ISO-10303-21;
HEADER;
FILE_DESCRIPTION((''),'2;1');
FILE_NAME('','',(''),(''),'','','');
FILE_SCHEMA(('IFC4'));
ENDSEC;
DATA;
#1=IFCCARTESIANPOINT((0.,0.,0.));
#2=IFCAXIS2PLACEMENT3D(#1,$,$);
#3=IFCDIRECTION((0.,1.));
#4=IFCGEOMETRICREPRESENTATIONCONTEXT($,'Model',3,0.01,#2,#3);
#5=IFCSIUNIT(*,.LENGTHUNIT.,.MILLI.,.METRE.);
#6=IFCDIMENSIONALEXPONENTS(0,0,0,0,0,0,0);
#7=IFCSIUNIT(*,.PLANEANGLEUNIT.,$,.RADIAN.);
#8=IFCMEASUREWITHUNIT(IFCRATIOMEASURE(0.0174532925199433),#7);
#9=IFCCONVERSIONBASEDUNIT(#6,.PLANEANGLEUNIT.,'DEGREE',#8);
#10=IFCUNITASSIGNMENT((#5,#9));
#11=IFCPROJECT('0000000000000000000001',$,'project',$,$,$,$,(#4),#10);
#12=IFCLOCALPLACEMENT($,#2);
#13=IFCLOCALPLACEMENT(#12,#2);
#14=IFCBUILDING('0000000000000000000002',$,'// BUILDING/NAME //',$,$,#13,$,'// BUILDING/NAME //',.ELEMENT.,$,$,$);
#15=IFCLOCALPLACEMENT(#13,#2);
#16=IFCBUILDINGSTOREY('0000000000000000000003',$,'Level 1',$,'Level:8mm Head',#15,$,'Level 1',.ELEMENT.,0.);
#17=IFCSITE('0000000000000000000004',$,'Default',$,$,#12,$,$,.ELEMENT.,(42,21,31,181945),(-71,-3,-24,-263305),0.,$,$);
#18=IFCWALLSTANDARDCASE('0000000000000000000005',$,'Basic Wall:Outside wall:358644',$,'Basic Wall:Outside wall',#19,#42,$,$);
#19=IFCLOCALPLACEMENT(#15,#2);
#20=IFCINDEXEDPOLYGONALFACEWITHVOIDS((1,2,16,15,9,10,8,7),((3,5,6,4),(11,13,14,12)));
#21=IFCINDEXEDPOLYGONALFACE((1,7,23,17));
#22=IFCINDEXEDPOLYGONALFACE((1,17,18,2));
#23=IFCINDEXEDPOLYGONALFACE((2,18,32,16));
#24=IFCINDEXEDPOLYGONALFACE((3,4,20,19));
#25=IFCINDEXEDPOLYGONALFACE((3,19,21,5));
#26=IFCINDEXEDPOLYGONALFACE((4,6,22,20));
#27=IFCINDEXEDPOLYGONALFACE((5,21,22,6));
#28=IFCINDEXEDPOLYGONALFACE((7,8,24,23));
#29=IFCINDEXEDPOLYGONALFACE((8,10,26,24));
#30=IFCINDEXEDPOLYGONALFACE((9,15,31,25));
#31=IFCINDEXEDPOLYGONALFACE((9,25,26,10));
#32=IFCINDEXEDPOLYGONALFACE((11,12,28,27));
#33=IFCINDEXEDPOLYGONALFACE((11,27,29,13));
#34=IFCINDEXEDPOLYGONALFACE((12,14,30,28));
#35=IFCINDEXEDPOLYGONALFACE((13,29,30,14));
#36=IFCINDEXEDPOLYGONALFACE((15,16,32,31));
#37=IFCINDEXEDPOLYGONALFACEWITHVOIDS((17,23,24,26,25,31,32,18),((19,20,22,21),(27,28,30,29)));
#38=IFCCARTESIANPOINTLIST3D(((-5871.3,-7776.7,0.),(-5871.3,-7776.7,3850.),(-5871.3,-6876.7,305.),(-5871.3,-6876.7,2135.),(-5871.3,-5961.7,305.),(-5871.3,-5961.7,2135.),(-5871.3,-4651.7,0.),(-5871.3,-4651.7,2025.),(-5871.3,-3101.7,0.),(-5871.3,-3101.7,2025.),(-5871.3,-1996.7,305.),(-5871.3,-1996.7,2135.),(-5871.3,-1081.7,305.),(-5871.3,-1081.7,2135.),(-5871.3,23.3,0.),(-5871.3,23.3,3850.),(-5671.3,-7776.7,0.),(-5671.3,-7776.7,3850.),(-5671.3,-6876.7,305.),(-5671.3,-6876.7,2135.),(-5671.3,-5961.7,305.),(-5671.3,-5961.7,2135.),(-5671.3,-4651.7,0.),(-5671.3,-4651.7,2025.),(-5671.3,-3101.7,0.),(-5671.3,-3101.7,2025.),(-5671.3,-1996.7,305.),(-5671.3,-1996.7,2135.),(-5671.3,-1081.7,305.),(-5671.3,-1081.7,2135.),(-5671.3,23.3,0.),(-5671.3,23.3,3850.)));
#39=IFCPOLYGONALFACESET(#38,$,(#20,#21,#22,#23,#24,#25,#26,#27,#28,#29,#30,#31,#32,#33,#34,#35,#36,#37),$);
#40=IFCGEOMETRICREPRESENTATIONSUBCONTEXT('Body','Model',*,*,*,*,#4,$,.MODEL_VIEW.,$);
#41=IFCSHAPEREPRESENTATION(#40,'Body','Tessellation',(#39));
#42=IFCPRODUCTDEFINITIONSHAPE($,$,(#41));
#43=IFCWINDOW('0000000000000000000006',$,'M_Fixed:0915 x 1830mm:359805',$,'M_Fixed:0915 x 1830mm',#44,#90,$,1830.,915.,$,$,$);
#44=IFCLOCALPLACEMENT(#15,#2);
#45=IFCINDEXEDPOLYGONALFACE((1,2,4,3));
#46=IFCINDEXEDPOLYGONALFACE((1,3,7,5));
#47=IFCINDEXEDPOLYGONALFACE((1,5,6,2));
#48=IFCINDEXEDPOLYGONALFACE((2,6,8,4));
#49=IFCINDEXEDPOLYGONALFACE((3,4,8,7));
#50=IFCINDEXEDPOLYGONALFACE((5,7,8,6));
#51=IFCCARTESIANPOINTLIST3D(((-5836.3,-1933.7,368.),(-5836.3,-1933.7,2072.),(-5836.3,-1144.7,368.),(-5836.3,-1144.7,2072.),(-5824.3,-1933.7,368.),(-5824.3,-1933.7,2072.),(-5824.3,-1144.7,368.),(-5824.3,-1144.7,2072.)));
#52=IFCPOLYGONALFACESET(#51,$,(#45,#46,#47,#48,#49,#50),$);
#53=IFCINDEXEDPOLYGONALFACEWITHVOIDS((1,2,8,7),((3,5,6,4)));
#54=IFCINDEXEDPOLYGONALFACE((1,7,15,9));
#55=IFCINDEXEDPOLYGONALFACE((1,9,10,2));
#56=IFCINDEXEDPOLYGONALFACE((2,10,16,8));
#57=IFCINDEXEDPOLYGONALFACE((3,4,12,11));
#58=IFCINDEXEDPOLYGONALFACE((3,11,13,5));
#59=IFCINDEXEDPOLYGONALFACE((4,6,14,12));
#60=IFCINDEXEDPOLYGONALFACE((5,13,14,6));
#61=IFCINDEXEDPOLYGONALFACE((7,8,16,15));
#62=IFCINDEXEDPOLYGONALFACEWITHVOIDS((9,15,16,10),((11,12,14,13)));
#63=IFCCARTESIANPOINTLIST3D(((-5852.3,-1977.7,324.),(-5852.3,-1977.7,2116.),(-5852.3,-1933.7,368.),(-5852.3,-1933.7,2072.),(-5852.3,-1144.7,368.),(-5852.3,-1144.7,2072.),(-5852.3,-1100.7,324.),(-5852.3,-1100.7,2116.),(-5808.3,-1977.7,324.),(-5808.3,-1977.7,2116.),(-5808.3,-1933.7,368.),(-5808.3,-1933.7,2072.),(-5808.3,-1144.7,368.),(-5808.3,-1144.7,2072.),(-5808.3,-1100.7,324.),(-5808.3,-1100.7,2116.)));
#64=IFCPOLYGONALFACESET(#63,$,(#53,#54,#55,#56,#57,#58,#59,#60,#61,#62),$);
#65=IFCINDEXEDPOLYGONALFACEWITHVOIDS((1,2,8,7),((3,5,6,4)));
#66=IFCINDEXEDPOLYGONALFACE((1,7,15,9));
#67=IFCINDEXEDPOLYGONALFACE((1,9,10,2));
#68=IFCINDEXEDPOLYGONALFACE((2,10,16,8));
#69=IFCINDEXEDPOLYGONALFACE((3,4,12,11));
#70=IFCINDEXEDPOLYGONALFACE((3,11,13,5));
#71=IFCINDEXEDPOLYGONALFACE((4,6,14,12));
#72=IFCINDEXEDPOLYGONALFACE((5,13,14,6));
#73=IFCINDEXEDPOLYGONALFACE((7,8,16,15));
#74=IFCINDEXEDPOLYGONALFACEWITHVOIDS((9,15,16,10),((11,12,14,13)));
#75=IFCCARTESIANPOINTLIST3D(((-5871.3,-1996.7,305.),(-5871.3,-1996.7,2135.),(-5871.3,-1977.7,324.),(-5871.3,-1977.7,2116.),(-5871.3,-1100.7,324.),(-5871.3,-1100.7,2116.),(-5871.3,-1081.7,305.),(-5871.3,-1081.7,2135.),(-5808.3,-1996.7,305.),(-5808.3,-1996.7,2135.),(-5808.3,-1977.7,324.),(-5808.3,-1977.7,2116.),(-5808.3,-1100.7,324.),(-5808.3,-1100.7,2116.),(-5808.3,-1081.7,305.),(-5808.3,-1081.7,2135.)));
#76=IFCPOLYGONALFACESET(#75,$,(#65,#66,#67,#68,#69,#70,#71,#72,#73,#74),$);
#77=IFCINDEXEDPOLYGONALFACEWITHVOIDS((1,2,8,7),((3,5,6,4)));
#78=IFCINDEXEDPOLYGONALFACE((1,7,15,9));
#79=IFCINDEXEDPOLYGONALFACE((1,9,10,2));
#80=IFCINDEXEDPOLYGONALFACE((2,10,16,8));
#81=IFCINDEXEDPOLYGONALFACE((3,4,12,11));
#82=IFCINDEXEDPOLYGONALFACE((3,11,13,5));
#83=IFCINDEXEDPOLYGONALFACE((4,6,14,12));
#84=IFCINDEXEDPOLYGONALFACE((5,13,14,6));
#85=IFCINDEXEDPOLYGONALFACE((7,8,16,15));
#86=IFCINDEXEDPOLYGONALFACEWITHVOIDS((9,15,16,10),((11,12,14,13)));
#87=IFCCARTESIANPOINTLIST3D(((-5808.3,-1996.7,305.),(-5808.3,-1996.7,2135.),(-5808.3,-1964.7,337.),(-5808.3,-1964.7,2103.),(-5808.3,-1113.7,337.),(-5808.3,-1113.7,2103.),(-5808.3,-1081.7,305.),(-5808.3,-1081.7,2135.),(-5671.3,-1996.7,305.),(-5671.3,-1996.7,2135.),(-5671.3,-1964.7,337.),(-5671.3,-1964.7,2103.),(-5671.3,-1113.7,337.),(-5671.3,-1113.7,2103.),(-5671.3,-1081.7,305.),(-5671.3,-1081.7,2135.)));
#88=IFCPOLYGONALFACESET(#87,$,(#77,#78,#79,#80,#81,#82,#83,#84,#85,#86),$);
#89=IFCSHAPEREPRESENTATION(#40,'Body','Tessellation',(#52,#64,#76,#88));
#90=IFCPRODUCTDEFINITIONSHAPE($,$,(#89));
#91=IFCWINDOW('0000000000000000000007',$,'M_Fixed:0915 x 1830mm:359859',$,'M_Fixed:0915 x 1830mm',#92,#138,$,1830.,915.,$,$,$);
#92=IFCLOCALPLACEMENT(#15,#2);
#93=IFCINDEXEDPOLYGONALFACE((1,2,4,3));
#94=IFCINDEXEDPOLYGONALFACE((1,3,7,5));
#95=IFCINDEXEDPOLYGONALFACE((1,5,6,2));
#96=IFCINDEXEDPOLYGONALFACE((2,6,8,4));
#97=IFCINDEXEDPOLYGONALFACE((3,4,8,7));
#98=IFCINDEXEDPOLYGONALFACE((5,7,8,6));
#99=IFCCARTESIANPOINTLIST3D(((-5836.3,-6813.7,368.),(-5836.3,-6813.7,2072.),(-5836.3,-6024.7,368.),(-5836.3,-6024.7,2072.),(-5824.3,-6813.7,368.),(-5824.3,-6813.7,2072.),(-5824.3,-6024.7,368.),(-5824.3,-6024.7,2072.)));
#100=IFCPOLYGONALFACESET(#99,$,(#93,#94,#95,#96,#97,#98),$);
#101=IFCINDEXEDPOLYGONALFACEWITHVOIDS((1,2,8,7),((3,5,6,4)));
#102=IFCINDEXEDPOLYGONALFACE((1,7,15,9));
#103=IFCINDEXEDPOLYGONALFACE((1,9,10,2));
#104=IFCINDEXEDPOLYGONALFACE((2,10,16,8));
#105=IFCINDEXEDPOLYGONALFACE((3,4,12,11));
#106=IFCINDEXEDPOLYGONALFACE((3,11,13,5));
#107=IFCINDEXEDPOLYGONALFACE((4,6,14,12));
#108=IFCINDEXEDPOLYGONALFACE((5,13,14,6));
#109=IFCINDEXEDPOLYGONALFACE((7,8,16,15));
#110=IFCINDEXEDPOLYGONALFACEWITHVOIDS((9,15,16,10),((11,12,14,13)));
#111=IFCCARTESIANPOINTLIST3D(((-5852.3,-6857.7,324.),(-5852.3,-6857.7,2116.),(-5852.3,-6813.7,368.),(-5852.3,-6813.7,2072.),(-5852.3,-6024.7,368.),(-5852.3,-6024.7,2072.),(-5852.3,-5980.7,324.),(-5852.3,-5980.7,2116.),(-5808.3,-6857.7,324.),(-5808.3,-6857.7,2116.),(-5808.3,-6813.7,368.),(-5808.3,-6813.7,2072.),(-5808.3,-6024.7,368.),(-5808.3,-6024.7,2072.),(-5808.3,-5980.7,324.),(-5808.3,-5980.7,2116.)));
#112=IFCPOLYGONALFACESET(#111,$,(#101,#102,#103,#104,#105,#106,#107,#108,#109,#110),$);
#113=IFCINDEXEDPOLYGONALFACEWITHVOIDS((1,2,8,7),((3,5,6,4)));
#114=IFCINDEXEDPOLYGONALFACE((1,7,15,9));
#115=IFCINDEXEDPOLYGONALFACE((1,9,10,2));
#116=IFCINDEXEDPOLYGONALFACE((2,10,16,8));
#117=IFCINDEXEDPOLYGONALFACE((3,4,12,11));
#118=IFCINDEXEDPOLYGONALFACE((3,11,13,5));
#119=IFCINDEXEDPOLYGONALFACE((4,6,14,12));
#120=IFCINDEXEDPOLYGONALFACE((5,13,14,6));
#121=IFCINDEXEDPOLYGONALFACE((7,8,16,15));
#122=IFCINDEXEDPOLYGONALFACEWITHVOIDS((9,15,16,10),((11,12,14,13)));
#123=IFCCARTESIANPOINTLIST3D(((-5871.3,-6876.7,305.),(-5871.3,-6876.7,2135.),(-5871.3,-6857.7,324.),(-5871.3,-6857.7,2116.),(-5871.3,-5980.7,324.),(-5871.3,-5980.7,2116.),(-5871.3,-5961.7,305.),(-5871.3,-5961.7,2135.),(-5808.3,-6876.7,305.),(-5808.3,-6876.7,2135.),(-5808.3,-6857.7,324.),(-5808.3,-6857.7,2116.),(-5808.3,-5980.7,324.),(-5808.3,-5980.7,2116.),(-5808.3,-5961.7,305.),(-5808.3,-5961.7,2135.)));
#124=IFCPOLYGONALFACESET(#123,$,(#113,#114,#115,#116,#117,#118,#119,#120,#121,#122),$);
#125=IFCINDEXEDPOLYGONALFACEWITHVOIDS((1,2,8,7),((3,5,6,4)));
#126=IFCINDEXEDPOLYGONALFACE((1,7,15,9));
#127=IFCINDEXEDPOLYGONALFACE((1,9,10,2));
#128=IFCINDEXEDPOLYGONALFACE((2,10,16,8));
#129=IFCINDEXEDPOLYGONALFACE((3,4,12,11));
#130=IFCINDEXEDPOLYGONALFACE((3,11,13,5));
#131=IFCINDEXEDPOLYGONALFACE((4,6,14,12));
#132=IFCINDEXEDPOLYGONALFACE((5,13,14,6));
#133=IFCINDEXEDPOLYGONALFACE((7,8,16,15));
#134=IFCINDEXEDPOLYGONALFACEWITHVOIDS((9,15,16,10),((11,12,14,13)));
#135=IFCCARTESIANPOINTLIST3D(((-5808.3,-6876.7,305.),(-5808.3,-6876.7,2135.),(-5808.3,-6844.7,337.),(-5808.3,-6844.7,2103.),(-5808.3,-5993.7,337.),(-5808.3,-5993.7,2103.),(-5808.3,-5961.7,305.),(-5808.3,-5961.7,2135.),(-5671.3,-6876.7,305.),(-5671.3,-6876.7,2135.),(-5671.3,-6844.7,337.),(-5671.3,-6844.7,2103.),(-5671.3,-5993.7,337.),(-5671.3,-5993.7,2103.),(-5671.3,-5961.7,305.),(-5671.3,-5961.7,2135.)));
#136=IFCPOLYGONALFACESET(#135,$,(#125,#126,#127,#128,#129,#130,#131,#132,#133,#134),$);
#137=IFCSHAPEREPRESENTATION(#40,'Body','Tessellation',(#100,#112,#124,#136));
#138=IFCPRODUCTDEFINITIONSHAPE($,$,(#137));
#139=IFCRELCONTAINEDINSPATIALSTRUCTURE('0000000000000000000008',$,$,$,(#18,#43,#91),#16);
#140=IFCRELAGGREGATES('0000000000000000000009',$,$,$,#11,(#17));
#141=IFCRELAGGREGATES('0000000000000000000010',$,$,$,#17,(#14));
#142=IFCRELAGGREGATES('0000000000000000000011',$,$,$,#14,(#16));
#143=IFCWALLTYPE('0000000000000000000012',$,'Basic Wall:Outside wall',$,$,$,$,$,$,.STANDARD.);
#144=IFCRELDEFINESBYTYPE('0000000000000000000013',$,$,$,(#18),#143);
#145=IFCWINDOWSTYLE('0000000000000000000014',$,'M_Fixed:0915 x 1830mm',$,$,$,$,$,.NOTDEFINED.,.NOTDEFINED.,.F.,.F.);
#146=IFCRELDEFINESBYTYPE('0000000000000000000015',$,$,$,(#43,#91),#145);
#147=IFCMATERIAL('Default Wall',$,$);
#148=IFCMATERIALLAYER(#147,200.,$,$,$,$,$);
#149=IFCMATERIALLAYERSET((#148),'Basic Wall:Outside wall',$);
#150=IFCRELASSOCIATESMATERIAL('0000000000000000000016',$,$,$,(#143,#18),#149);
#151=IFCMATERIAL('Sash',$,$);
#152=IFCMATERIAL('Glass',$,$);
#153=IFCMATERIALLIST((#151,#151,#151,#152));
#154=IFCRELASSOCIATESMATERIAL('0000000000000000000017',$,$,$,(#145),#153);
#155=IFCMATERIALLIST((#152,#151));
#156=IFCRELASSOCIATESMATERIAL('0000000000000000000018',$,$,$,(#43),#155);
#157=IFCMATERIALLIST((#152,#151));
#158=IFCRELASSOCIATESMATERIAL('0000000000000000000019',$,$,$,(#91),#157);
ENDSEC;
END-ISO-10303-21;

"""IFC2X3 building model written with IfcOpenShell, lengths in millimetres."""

from ifc_helpers import new_model, entity, si_unit, converted_unit, direction, frame, frame_2d, origin, place, context, subcontext, project, spatial, polyline, rectangle, outline, extrude, clip, halfspace, bounded_halfspace, source, transform, mapped, material, material_list, layer, layer_set, layer_usage, type_object, type_shapes, element, fill, save


model = new_model("IFC2X3")

# Units and contexts
model_context = context("Model", 3, precision=0.01, world=origin(), true_north=direction((0.0, 1.0)))
body_context = subcontext(model_context, "Body", "Model", "MODEL_VIEW")
ifc_project = project(units=[si_unit("LENGTHUNIT", "METRE", prefix="MILLI"), converted_unit("PLANEANGLEUNIT", "DEGREE", entity("IfcRatioMeasure", 0.0174532925199433), si_unit("PLANEANGLEUNIT", "RADIAN"), dimensions=[0, 0, 0, 0, 0, 0, 0])], contexts=[model_context])

# Site, building, storey
site_placement = place(None, origin())
site = spatial("IfcSite", under=ifc_project, at=site_placement, Name="Default", CompositionType="ELEMENT", RefLatitude=(42, 21, 31, 181945), RefLongitude=(-71, -3, -24, -263305), RefElevation=0.0)
building_placement = place(site_placement, origin())
building = spatial("IfcBuilding", under=site, at=building_placement, Name="// BUILDING/NAME //", LongName="// BUILDING/NAME //", CompositionType="ELEMENT")
storey_placement = place(building_placement, origin())
storey = spatial("IfcBuildingStorey", under=building, at=storey_placement, Name="Level 1", ObjectType="Level:8mm Head", LongName="Level 1", CompositionType="ELEMENT", Elevation=0.0)

# Shared definitions
ifc_material_1 = material(Name="Default Wall")
ifc_layer_1 = layer(ifc_material_1, 200.0)
ifc_layer_set_1 = layer_set([ifc_layer_1], Name="Basic Wall:Outside wall")
wall_type_1 = type_object("IfcWallType", Name="Basic Wall:Outside wall", PredefinedType="STANDARD", material=ifc_layer_set_1)
ifc_material_2 = material(Name="Glass")
ifc_material_3 = material(Name="Sash")
ifc_material_list_1 = material_list([ifc_material_3, ifc_material_3, ifc_material_3, ifc_material_2])
window_style = type_object("IfcWindowStyle", Name="M_Fixed:0915 x 1830mm", ConstructionType="NOTDEFINED", OperationType="NOTDEFINED", ParameterTakesPrecedence=False, Sizeable=False, material=ifc_material_list_1)
shared_shape_1 = source(origin(), body_context, "Body", "SweptSolid", [
    extrude(rectangle(XDim=12.0, YDim=789.0, at=frame_2d((0.0, 0.0), x_axis=(1.0, 0.0))), frame((457.5, 159.0, 63.0), z_axis=(0.0, 0.0, 1.0), x_axis=(0.0, -1.0, 0.0)), (0.0, 0.0, 1.0), 1704.0),
    extrude(outline(polyline([(-438.5, -896.0), (438.5, -896.0), (438.5, 896.0), (-438.5, 896.0), (-438.5, -896.0)]), holes=[polyline([(-394.5, -852.0), (-394.5, 852.0), (394.5, 852.0), (394.5, -852.0), (-394.5, -852.0)])]), frame((457.5, 137.0, 915.0), z_axis=(0.0, 1.0, 0.0), x_axis=(1.0, 0.0, 0.0)), (0.0, 0.0, 1.0), 44.0),
    extrude(outline(polyline([(-457.5, -915.0), (457.5, -915.0), (457.5, 915.0), (-457.5, 915.0), (-457.5, -915.0)]), holes=[polyline([(-438.5, -896.0), (-438.5, 896.0), (438.5, 896.0), (438.5, -896.0), (-438.5, -896.0)])]), frame((457.5, 137.0, 915.0), z_axis=(0.0, 1.0, 0.0), x_axis=(1.0, 0.0, 0.0)), (0.0, 0.0, 1.0), 63.0),
    extrude(outline(polyline([(-457.5, -915.0), (457.5, -915.0), (457.5, 915.0), (-457.5, 915.0), (-457.5, -915.0)]), holes=[polyline([(-425.5, -883.0), (-425.5, 883.0), (425.5, 883.0), (425.5, -883.0), (-425.5, -883.0)])]), frame((457.5, 0.0, 915.0), z_axis=(0.0, 1.0, 0.0), x_axis=(1.0, 0.0, 0.0)), (0.0, 0.0, 1.0), 137.0),
])
type_shapes(window_style, [shared_shape_1])

# Wall, openings, windows
ifc_layer_usage_1 = layer_usage(ifc_layer_set_1, "AXIS2", "NEGATIVE", 100.0)
wall_1_placement = place(storey_placement, frame((-5771.3, -7776.7, 0.0), z_axis=(0.0, 0.0, 1.0), x_axis=(0.0, 1.0, 0.0)))
wall_1 = element("IfcWallStandardCase", 1, at=wall_1_placement, inside=storey, type_object=wall_type_1, material=ifc_layer_usage_1, Name="Basic Wall:Outside wall:358644", ObjectType="Basic Wall:Outside wall", context=body_context, shape_type="Clipping", body=[
    clip(clip(extrude(rectangle(XDim=7800.0, YDim=200.0, at=frame_2d((3900.0, 0.0), x_axis=(-1.0, 0.0))), origin(), (0.0, 0.0, 1.0), 3850.0), bounded_halfspace(frame((0.0, -100.0, 3850.0), z_axis=(0.0, 0.0, -1.0), x_axis=(-1.0, 0.0, 0.0)), True, frame((0.0, -100.0, 3850.0), z_axis=(0.0, 0.0, -1.0), x_axis=(-1.0, 0.0, 0.0)), polyline([(0.0, 0.0), (0.0, 200.0), (-7800.0, 200.0), (-7800.0, 0.0), (0.0, 0.0)]))), halfspace(origin(), True)),
])
opening_1_placement = place(wall_1_placement, frame((3125.0, -100.0, 0.0)))
element("IfcOpeningElement", 2, at=opening_1_placement, cuts=wall_1, ObjectType="Opening", context=body_context, shape_type="SweptSolid", body=[
    extrude(rectangle(XDim=2025.0, YDim=1550.0, at=frame_2d((1012.5, 775.0), x_axis=(1.0, 0.0))), frame((0.0, 0.0, 0.0), z_axis=(0.0, 1.0, 0.0), x_axis=(0.0, 0.0, 1.0)), (0.0, 0.0, 1.0), 200.0),
])
opening_2_placement = place(wall_1_placement, frame((5780.0, -100.0, 305.0)))
opening_2 = element("IfcOpeningElement", 3, at=opening_2_placement, cuts=wall_1, ObjectType="Opening", context=body_context, shape_type="SweptSolid", body=[
    extrude(rectangle(XDim=1830.0, YDim=915.0, at=frame_2d((915.0, 457.5), x_axis=(1.0, 0.0))), frame((0.0, 0.0, 0.0), z_axis=(0.0, 1.0, 0.0), x_axis=(0.0, 0.0, 1.0)), (0.0, 0.0, 1.0), 200.0),
])
opening_3_placement = place(wall_1_placement, frame((900.0, -100.0, 305.0)))
opening_3 = element("IfcOpeningElement", 4, at=opening_3_placement, cuts=wall_1, ObjectType="Opening", context=body_context, shape_type="SweptSolid", body=[
    extrude(rectangle(XDim=1830.0, YDim=915.0, at=frame_2d((915.0, 457.5), x_axis=(1.0, 0.0))), frame((0.0, 0.0, 0.0), z_axis=(0.0, 1.0, 0.0), x_axis=(0.0, 0.0, 1.0)), (0.0, 0.0, 1.0), 200.0),
])
ifc_material_list_2 = material_list([ifc_material_2, ifc_material_3])
window_1_placement = place(opening_2_placement, origin())
window_1 = element("IfcWindow", 5, at=window_1_placement, inside=storey, type_object=window_style, material=ifc_material_list_2, Name="M_Fixed:0915 x 1830mm:359805", ObjectType="M_Fixed:0915 x 1830mm", OverallHeight=1830.0, OverallWidth=915.0, context=body_context, shape_type="MappedRepresentation", body=[
    mapped(shared_shape_1, transform((0.0, 0.0, 0.0), scale=1.0)),
])
fill(opening_2, window_1)
ifc_material_list_3 = material_list([ifc_material_2, ifc_material_3])
window_2_placement = place(opening_3_placement, origin())
window_2 = element("IfcWindow", 6, at=window_2_placement, inside=storey, type_object=window_style, material=ifc_material_list_3, Name="M_Fixed:0915 x 1830mm:359859", ObjectType="M_Fixed:0915 x 1830mm", OverallHeight=1830.0, OverallWidth=915.0, context=body_context, shape_type="MappedRepresentation", body=[
    mapped(shared_shape_1, transform((0.0, 0.0, 0.0), scale=1.0)),
])
fill(opening_3, window_2)

save(model, "model.ifc")
